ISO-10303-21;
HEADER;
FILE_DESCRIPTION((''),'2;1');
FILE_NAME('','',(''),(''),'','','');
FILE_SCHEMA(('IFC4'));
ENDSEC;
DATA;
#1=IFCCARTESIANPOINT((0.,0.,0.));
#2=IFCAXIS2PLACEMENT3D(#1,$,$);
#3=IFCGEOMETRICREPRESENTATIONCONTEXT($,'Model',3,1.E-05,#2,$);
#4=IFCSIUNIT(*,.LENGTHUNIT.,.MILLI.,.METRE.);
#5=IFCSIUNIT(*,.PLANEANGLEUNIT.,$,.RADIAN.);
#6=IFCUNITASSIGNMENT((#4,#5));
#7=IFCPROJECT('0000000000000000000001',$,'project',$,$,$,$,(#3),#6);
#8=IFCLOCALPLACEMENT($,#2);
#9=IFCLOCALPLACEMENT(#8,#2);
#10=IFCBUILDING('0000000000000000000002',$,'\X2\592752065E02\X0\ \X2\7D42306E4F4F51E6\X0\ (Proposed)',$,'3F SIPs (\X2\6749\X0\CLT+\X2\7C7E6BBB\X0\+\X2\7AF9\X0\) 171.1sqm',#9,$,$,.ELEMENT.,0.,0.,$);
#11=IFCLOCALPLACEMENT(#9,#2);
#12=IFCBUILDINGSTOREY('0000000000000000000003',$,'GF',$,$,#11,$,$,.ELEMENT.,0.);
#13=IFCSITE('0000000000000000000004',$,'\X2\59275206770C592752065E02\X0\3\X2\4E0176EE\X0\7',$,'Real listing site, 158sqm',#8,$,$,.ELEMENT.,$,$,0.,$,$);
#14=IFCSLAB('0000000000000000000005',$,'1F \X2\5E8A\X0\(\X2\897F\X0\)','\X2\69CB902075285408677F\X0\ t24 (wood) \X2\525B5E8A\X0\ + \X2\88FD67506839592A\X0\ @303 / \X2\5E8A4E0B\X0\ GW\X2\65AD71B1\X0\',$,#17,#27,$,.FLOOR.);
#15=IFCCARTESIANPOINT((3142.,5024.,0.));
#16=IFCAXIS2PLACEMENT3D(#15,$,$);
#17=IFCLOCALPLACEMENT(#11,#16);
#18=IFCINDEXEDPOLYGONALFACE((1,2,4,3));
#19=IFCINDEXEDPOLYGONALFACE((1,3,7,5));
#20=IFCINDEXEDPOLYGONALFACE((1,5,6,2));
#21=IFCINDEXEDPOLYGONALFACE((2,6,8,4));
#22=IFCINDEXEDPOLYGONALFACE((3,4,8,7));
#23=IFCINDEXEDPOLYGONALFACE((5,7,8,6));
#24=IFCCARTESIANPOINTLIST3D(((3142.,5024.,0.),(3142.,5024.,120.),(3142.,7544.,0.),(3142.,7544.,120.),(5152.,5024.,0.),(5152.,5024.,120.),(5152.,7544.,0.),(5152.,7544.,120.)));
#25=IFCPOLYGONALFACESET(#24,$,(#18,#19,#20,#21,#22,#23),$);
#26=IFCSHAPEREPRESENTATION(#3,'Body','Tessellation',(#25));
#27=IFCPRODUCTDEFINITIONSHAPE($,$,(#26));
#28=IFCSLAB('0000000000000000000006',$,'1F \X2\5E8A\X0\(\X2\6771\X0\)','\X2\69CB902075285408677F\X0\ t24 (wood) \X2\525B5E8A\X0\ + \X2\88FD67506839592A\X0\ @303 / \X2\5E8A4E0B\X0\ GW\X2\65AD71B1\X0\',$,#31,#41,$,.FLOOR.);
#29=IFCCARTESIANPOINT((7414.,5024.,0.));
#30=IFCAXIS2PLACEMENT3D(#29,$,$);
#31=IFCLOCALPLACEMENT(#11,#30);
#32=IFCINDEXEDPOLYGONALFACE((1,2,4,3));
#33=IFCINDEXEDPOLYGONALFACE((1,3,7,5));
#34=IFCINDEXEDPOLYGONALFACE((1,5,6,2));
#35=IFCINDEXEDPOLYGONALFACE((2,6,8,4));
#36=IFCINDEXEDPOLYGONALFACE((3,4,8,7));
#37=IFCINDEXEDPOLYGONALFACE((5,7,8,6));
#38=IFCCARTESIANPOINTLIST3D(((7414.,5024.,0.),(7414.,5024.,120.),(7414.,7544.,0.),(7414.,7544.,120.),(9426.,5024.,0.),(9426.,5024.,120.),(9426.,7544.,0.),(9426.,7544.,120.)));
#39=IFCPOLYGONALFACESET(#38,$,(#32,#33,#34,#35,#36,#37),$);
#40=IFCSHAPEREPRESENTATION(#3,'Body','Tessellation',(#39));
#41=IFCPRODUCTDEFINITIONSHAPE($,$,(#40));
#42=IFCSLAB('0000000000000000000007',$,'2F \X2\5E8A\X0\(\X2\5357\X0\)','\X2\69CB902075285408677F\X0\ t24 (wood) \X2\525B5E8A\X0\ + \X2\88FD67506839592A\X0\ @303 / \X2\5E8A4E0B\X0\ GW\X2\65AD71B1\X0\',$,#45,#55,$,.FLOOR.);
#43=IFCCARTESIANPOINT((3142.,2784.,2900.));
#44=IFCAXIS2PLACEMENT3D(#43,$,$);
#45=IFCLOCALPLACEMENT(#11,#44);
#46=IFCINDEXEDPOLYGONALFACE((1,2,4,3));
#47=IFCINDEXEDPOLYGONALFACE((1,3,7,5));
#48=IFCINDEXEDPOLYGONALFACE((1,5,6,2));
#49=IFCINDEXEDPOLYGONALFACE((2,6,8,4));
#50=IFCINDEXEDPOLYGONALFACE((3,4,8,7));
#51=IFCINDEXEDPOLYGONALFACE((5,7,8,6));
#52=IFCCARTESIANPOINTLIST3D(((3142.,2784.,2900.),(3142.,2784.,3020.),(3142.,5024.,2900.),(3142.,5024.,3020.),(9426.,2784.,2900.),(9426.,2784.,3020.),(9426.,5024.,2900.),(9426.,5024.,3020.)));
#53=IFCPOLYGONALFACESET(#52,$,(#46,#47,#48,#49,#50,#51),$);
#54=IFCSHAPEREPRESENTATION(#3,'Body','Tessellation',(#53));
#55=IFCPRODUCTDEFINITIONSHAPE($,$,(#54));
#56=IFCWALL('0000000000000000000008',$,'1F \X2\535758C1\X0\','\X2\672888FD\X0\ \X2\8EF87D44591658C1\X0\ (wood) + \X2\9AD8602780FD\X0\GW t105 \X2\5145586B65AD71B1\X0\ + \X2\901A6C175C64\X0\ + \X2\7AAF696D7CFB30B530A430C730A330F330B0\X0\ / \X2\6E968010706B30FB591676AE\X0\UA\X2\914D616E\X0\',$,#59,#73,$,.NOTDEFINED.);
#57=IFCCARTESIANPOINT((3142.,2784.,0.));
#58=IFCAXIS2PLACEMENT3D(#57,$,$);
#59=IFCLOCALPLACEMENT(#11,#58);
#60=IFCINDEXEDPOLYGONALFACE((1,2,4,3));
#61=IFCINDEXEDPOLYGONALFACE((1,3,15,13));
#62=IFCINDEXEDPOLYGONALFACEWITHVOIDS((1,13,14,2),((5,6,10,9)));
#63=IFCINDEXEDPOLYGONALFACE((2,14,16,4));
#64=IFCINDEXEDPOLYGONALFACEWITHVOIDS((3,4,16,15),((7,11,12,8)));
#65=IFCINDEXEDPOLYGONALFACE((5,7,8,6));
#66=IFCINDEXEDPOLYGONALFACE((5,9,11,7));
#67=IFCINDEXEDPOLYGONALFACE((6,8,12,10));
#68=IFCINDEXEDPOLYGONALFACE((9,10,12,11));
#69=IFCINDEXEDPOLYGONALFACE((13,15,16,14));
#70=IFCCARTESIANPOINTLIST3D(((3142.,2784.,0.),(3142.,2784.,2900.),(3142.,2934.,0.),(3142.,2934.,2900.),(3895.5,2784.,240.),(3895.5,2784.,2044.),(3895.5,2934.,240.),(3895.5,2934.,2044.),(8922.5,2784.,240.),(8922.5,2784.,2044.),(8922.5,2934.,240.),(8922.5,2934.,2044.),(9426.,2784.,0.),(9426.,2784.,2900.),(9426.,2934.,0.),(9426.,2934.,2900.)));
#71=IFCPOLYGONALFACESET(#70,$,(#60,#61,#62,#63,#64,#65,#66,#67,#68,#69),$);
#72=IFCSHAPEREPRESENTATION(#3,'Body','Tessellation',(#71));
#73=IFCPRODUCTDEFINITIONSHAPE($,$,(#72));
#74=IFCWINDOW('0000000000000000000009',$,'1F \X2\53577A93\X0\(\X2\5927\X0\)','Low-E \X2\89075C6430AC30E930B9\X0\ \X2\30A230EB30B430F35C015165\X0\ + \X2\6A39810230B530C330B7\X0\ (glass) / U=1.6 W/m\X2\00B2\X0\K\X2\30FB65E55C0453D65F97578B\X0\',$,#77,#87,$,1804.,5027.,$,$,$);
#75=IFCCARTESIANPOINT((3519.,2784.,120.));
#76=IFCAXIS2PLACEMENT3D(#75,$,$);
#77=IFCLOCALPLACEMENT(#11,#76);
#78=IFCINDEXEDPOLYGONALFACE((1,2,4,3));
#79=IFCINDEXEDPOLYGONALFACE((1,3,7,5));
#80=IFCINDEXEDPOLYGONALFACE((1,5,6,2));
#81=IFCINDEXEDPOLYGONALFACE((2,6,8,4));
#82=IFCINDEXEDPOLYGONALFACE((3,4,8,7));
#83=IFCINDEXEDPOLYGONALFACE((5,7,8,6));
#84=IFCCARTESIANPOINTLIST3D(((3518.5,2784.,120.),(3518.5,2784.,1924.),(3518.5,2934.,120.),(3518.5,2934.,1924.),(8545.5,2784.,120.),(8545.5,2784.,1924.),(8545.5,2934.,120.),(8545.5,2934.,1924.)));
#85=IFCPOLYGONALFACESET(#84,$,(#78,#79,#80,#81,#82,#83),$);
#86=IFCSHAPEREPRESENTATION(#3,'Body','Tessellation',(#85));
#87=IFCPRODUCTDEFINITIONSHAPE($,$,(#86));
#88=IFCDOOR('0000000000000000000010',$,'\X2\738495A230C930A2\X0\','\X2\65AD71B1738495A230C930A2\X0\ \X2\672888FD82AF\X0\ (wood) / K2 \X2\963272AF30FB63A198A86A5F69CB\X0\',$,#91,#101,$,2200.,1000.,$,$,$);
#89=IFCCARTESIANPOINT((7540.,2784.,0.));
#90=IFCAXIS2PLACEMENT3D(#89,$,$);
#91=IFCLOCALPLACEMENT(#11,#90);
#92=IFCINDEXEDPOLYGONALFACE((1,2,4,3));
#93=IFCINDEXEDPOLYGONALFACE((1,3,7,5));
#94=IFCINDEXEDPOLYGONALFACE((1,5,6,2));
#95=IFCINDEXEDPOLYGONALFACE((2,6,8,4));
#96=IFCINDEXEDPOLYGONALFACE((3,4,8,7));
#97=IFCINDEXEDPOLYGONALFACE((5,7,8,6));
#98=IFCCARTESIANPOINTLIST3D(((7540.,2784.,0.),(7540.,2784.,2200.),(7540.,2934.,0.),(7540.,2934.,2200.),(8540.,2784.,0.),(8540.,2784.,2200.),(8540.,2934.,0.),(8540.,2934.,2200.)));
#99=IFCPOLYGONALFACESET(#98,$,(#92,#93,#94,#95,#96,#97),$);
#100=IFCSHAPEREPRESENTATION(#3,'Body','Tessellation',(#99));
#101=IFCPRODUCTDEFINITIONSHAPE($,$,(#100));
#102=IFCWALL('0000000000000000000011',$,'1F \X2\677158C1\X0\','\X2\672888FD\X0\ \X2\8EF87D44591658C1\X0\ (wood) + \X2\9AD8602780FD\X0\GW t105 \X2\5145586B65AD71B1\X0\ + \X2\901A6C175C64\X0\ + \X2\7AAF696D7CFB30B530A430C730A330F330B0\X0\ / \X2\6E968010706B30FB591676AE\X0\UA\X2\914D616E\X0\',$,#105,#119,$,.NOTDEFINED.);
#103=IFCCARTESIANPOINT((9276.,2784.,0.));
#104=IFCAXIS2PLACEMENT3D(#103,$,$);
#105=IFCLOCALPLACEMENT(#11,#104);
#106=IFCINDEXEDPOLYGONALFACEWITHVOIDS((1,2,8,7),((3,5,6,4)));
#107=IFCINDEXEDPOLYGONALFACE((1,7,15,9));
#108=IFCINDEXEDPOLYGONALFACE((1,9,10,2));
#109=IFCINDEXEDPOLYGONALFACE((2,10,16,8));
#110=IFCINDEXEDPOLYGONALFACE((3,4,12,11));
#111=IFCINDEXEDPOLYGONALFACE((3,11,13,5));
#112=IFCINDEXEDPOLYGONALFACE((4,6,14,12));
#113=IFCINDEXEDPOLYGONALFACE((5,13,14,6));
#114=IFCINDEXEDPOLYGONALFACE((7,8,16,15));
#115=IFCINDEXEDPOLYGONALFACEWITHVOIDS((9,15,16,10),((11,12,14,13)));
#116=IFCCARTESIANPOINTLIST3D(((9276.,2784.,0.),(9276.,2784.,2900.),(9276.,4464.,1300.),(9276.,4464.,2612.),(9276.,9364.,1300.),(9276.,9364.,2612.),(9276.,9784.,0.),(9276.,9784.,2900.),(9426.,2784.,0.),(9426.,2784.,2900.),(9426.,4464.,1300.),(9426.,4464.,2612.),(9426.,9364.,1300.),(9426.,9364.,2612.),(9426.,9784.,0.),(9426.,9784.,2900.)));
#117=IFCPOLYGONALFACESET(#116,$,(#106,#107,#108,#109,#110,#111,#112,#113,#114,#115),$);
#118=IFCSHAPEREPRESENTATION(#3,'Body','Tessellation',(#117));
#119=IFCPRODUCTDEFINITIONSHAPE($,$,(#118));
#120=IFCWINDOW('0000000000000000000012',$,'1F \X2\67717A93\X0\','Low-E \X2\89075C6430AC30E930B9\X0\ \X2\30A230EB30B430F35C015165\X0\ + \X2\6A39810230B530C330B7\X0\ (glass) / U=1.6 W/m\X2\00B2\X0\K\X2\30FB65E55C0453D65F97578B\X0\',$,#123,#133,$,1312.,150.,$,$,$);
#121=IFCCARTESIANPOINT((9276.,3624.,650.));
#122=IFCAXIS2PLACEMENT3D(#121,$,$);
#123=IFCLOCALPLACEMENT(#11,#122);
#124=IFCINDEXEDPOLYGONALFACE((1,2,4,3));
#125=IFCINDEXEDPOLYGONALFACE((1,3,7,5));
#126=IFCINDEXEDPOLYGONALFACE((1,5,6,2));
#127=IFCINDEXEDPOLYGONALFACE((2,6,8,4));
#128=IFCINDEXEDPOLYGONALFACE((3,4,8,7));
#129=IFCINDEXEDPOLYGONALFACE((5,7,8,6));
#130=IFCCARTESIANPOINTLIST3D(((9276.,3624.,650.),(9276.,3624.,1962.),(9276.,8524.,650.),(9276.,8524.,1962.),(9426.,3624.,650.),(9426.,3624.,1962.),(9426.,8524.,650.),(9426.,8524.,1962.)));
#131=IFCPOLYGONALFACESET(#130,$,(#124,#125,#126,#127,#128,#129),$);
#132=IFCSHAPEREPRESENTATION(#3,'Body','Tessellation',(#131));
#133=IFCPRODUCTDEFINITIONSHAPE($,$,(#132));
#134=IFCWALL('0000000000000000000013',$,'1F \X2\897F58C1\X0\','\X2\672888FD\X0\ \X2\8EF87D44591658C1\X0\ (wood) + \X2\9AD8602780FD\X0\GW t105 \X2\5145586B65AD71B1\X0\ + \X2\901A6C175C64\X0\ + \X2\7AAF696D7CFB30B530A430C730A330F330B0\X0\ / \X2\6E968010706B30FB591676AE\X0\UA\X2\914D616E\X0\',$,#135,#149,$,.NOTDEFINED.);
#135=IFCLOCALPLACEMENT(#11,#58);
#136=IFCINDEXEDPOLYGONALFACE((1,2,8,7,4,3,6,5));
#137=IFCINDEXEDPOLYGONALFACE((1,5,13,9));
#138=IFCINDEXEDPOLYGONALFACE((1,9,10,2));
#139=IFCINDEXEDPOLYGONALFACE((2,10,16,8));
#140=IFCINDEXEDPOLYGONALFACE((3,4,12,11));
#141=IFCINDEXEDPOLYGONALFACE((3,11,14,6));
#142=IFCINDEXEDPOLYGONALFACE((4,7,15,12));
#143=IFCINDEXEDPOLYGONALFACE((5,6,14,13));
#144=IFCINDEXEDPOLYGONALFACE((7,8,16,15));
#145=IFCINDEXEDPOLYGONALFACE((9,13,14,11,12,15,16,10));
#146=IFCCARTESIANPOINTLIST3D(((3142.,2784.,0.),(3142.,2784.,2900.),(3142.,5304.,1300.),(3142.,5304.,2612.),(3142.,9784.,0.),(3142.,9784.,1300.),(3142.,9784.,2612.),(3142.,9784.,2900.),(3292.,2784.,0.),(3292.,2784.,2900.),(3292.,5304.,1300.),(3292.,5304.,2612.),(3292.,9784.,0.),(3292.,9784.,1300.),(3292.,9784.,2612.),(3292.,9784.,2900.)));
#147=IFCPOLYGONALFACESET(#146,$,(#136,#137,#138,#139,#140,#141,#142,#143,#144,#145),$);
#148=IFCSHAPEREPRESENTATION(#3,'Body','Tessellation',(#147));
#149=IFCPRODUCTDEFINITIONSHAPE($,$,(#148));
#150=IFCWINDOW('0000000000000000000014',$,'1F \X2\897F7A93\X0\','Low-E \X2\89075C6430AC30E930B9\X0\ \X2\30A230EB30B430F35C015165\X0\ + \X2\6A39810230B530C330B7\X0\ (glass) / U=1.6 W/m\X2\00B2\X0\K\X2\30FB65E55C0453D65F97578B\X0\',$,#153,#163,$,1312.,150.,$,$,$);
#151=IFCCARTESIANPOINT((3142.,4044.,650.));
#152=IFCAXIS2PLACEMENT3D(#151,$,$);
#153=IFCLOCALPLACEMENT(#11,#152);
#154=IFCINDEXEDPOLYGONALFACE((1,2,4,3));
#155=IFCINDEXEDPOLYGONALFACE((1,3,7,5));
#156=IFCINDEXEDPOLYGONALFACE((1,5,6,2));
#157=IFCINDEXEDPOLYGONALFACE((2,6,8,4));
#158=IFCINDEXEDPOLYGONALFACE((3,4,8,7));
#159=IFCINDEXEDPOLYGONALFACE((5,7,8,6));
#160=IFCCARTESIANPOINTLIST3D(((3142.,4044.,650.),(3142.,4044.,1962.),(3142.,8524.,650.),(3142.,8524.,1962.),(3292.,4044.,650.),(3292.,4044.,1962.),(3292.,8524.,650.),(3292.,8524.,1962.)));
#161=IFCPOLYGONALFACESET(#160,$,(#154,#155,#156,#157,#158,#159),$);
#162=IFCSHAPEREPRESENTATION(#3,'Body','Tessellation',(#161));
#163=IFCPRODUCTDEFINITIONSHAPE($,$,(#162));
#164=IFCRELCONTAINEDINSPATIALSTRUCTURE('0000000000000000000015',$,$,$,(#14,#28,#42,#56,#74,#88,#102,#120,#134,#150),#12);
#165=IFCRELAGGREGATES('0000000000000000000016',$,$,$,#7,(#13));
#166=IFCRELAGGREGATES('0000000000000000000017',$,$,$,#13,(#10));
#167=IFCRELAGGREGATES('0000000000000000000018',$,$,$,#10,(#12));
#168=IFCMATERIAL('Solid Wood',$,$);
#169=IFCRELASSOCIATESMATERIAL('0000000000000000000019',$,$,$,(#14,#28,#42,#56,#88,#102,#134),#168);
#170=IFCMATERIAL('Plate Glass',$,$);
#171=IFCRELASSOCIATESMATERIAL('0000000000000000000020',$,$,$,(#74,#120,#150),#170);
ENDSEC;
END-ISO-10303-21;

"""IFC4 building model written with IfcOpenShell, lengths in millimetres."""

from ifc_helpers import new_model, si_unit, frame, frame_2d, origin, place, context, project, spatial, rectangle, extrude, material, element, fill, save


model = new_model("IFC4")

# Units and contexts
model_context = context("Model", 3, precision=1e-05, world=origin())
ifc_project = project(units=[si_unit("LENGTHUNIT", "METRE", prefix="MILLI"), si_unit("PLANEANGLEUNIT", "RADIAN")], contexts=[model_context])

# Site, building, storey
site_placement = place(None, origin())
site = spatial("IfcSite", under=ifc_project, at=site_placement, Name="大分県大分市3丁目7", ObjectType="Real listing site, 158sqm", CompositionType="ELEMENT", RefElevation=0.0)
building_placement = place(site_placement, origin())
building = spatial("IfcBuilding", under=site, at=building_placement, Name="大分市 終の住処 (Proposed)", ObjectType="3F SIPs (杉CLT+籾殻+竹) 171.1sqm", CompositionType="ELEMENT", ElevationOfRefHeight=0.0, ElevationOfTerrain=0.0)
storey_placement = place(building_placement, origin())
storey = spatial("IfcBuildingStorey", under=building, at=storey_placement, Name="GF", CompositionType="ELEMENT", Elevation=0.0)

# Slabs
ifc_material_1 = material(Name="Solid Wood")
slab_1_placement = place(storey_placement, frame((3142.0, 5024.0, 0.0)))
element("IfcSlab", 1, at=slab_1_placement, inside=storey, material=ifc_material_1, Name="1F 床(西)", Description="構造用合板 t24 (wood) 剛床 + 製材根太 @303 / 床下 GW断熱", PredefinedType="FLOOR", context=model_context, shape_type="SweptSolid", body=[
    extrude(rectangle(XDim=2010.0, YDim=2520.0, at=frame_2d((1005.0, 1260.0))), frame((3142.0, 5024.0, 0.0)), (0.0, 0.0, 1.0), 120.0),
])
slab_2_placement = place(storey_placement, frame((7414.0, 5024.0, 0.0)))
element("IfcSlab", 2, at=slab_2_placement, inside=storey, material=ifc_material_1, Name="1F 床(東)", Description="構造用合板 t24 (wood) 剛床 + 製材根太 @303 / 床下 GW断熱", PredefinedType="FLOOR", context=model_context, shape_type="SweptSolid", body=[
    extrude(rectangle(XDim=2012.0, YDim=2520.0, at=frame_2d((1006.0, 1260.0))), frame((7414.0, 5024.0, 0.0)), (0.0, 0.0, 1.0), 120.0),
])
slab_3_placement = place(storey_placement, frame((3142.0, 2784.0, 2900.0)))
element("IfcSlab", 3, at=slab_3_placement, inside=storey, material=ifc_material_1, Name="2F 床(南)", Description="構造用合板 t24 (wood) 剛床 + 製材根太 @303 / 床下 GW断熱", PredefinedType="FLOOR", context=model_context, shape_type="SweptSolid", body=[
    extrude(rectangle(XDim=6284.0, YDim=2240.0, at=frame_2d((3142.0, 1120.0))), frame((3142.0, 2784.0, 2900.0)), (0.0, 0.0, 1.0), 120.0),
])

# Wall, openings, window, door
wall_1_placement = place(storey_placement, frame((3142.0, 2784.0, 0.0)))
wall_1 = element("IfcWall", 4, at=wall_1_placement, inside=storey, material=ifc_material_1, Name="1F 南壁", Description="木製 軸組外壁 (wood) + 高性能GW t105 充填断熱 + 通気層 + 窯業系サイディング / 準耐火・外皮UA配慮", PredefinedType="NOTDEFINED", context=model_context, shape_type="SweptSolid", body=[
    extrude(rectangle(XDim=6284.0, YDim=150.0, at=frame_2d((3142.0, 75.0))), frame((3142.0, 2784.0, 0.0)), (0.0, 0.0, 1.0), 2900.0),
])
opening_1_placement = place(storey_placement, frame((3519.0, 2784.0, 120.0)))
opening_1 = element("IfcOpeningElement", 5, at=opening_1_placement, cuts=wall_1, PredefinedType="NOTDEFINED", context=model_context, shape_type="SweptSolid", body=[
    extrude(rectangle(XDim=5027.0, YDim=150.0, at=frame_2d((2513.0, 75.0))), frame((3519.0, 2784.0, 120.0)), (0.0, 0.0, 1.0), 1804.0),
])
opening_2_placement = place(storey_placement, frame((7540.0, 2784.0, 0.0)))
opening_2 = element("IfcOpeningElement", 6, at=opening_2_placement, cuts=wall_1, PredefinedType="NOTDEFINED", context=model_context, shape_type="SweptSolid", body=[
    extrude(rectangle(XDim=1000.0, YDim=150.0, at=frame_2d((500.0, 75.0))), frame((7540.0, 2784.0, 0.0)), (0.0, 0.0, 1.0), 2200.0),
])
ifc_material_2 = material(Name="Plate Glass")
window_1_placement = place(storey_placement, frame((3519.0, 2784.0, 120.0)))
window_1 = element("IfcWindow", 7, at=window_1_placement, inside=storey, material=ifc_material_2, Name="1F 南窓(大)", Description="Low-E 複層ガラス アルゴン封入 + 樹脂サッシ (glass) / U=1.6 W/m²K・日射取得型", OverallHeight=1804.0, OverallWidth=5027.0, context=model_context, shape_type="SweptSolid", body=[
    extrude(rectangle(XDim=5027.0, YDim=150.0, at=frame_2d((2513.0, 75.0))), frame((3519.0, 2784.0, 120.0)), (0.0, 0.0, 1.0), 1804.0),
])
fill(opening_1, window_1)
door_placement = place(storey_placement, frame((7540.0, 2784.0, 0.0)))
door = element("IfcDoor", 8, at=door_placement, inside=storey, material=ifc_material_1, Name="玄関ドア", Description="断熱玄関ドア 木製芯 (wood) / K2 防犯・採風機構", OverallHeight=2200.0, OverallWidth=1000.0, context=model_context, shape_type="SweptSolid", body=[
    extrude(rectangle(XDim=1000.0, YDim=150.0, at=frame_2d((500.0, 75.0))), frame((7540.0, 2784.0, 0.0)), (0.0, 0.0, 1.0), 2200.0),
])
fill(opening_2, door)

# Walls, openings, windows
wall_2_placement = place(storey_placement, frame((9276.0, 2784.0, 0.0)))
wall_2 = element("IfcWall", 9, at=wall_2_placement, inside=storey, material=ifc_material_1, Name="1F 東壁", Description="木製 軸組外壁 (wood) + 高性能GW t105 充填断熱 + 通気層 + 窯業系サイディング / 準耐火・外皮UA配慮", PredefinedType="NOTDEFINED", context=model_context, shape_type="SweptSolid", body=[
    extrude(rectangle(XDim=150.0, YDim=7000.0, at=frame_2d((75.0, 3500.0))), frame((9276.0, 2784.0, 0.0)), (0.0, 0.0, 1.0), 2900.0),
])
opening_3_placement = place(storey_placement, frame((9276.0, 3624.0, 650.0)))
opening_3 = element("IfcOpeningElement", 10, at=opening_3_placement, cuts=wall_2, PredefinedType="NOTDEFINED", context=model_context, shape_type="SweptSolid", body=[
    extrude(rectangle(XDim=150.0, YDim=4900.0, at=frame_2d((75.0, 2450.0))), frame((9276.0, 3624.0, 650.0)), (0.0, 0.0, 1.0), 1312.0),
])
window_2_placement = place(storey_placement, frame((9276.0, 3624.0, 650.0)))
window_2 = element("IfcWindow", 11, at=window_2_placement, inside=storey, material=ifc_material_2, Name="1F 東窓", Description="Low-E 複層ガラス アルゴン封入 + 樹脂サッシ (glass) / U=1.6 W/m²K・日射取得型", OverallHeight=1312.0, OverallWidth=150.0, context=model_context, shape_type="SweptSolid", body=[
    extrude(rectangle(XDim=150.0, YDim=4900.0, at=frame_2d((75.0, 2450.0))), frame((9276.0, 3624.0, 650.0)), (0.0, 0.0, 1.0), 1312.0),
])
fill(opening_3, window_2)
wall_3_placement = place(storey_placement, frame((3142.0, 2784.0, 0.0)))
wall_3 = element("IfcWall", 12, at=wall_3_placement, inside=storey, material=ifc_material_1, Name="1F 西壁", Description="木製 軸組外壁 (wood) + 高性能GW t105 充填断熱 + 通気層 + 窯業系サイディング / 準耐火・外皮UA配慮", PredefinedType="NOTDEFINED", context=model_context, shape_type="SweptSolid", body=[
    extrude(rectangle(XDim=150.0, YDim=7000.0, at=frame_2d((75.0, 3500.0))), frame((3142.0, 2784.0, 0.0)), (0.0, 0.0, 1.0), 2900.0),
])
opening_4_placement = place(storey_placement, frame((3142.0, 4044.0, 650.0)))
opening_4 = element("IfcOpeningElement", 13, at=opening_4_placement, cuts=wall_3, PredefinedType="NOTDEFINED", context=model_context, shape_type="SweptSolid", body=[
    extrude(rectangle(XDim=150.0, YDim=4480.0, at=frame_2d((75.0, 2240.0))), frame((3142.0, 4044.0, 650.0)), (0.0, 0.0, 1.0), 1312.0),
])
window_3_placement = place(storey_placement, frame((3142.0, 4044.0, 650.0)))
window_3 = element("IfcWindow", 14, at=window_3_placement, inside=storey, material=ifc_material_2, Name="1F 西窓", Description="Low-E 複層ガラス アルゴン封入 + 樹脂サッシ (glass) / U=1.6 W/m²K・日射取得型", OverallHeight=1312.0, OverallWidth=150.0, context=model_context, shape_type="SweptSolid", body=[
    extrude(rectangle(XDim=150.0, YDim=4480.0, at=frame_2d((75.0, 2240.0))), frame((3142.0, 4044.0, 650.0)), (0.0, 0.0, 1.0), 1312.0),
])
fill(opening_4, window_3)

save(model, "model.ifc")
